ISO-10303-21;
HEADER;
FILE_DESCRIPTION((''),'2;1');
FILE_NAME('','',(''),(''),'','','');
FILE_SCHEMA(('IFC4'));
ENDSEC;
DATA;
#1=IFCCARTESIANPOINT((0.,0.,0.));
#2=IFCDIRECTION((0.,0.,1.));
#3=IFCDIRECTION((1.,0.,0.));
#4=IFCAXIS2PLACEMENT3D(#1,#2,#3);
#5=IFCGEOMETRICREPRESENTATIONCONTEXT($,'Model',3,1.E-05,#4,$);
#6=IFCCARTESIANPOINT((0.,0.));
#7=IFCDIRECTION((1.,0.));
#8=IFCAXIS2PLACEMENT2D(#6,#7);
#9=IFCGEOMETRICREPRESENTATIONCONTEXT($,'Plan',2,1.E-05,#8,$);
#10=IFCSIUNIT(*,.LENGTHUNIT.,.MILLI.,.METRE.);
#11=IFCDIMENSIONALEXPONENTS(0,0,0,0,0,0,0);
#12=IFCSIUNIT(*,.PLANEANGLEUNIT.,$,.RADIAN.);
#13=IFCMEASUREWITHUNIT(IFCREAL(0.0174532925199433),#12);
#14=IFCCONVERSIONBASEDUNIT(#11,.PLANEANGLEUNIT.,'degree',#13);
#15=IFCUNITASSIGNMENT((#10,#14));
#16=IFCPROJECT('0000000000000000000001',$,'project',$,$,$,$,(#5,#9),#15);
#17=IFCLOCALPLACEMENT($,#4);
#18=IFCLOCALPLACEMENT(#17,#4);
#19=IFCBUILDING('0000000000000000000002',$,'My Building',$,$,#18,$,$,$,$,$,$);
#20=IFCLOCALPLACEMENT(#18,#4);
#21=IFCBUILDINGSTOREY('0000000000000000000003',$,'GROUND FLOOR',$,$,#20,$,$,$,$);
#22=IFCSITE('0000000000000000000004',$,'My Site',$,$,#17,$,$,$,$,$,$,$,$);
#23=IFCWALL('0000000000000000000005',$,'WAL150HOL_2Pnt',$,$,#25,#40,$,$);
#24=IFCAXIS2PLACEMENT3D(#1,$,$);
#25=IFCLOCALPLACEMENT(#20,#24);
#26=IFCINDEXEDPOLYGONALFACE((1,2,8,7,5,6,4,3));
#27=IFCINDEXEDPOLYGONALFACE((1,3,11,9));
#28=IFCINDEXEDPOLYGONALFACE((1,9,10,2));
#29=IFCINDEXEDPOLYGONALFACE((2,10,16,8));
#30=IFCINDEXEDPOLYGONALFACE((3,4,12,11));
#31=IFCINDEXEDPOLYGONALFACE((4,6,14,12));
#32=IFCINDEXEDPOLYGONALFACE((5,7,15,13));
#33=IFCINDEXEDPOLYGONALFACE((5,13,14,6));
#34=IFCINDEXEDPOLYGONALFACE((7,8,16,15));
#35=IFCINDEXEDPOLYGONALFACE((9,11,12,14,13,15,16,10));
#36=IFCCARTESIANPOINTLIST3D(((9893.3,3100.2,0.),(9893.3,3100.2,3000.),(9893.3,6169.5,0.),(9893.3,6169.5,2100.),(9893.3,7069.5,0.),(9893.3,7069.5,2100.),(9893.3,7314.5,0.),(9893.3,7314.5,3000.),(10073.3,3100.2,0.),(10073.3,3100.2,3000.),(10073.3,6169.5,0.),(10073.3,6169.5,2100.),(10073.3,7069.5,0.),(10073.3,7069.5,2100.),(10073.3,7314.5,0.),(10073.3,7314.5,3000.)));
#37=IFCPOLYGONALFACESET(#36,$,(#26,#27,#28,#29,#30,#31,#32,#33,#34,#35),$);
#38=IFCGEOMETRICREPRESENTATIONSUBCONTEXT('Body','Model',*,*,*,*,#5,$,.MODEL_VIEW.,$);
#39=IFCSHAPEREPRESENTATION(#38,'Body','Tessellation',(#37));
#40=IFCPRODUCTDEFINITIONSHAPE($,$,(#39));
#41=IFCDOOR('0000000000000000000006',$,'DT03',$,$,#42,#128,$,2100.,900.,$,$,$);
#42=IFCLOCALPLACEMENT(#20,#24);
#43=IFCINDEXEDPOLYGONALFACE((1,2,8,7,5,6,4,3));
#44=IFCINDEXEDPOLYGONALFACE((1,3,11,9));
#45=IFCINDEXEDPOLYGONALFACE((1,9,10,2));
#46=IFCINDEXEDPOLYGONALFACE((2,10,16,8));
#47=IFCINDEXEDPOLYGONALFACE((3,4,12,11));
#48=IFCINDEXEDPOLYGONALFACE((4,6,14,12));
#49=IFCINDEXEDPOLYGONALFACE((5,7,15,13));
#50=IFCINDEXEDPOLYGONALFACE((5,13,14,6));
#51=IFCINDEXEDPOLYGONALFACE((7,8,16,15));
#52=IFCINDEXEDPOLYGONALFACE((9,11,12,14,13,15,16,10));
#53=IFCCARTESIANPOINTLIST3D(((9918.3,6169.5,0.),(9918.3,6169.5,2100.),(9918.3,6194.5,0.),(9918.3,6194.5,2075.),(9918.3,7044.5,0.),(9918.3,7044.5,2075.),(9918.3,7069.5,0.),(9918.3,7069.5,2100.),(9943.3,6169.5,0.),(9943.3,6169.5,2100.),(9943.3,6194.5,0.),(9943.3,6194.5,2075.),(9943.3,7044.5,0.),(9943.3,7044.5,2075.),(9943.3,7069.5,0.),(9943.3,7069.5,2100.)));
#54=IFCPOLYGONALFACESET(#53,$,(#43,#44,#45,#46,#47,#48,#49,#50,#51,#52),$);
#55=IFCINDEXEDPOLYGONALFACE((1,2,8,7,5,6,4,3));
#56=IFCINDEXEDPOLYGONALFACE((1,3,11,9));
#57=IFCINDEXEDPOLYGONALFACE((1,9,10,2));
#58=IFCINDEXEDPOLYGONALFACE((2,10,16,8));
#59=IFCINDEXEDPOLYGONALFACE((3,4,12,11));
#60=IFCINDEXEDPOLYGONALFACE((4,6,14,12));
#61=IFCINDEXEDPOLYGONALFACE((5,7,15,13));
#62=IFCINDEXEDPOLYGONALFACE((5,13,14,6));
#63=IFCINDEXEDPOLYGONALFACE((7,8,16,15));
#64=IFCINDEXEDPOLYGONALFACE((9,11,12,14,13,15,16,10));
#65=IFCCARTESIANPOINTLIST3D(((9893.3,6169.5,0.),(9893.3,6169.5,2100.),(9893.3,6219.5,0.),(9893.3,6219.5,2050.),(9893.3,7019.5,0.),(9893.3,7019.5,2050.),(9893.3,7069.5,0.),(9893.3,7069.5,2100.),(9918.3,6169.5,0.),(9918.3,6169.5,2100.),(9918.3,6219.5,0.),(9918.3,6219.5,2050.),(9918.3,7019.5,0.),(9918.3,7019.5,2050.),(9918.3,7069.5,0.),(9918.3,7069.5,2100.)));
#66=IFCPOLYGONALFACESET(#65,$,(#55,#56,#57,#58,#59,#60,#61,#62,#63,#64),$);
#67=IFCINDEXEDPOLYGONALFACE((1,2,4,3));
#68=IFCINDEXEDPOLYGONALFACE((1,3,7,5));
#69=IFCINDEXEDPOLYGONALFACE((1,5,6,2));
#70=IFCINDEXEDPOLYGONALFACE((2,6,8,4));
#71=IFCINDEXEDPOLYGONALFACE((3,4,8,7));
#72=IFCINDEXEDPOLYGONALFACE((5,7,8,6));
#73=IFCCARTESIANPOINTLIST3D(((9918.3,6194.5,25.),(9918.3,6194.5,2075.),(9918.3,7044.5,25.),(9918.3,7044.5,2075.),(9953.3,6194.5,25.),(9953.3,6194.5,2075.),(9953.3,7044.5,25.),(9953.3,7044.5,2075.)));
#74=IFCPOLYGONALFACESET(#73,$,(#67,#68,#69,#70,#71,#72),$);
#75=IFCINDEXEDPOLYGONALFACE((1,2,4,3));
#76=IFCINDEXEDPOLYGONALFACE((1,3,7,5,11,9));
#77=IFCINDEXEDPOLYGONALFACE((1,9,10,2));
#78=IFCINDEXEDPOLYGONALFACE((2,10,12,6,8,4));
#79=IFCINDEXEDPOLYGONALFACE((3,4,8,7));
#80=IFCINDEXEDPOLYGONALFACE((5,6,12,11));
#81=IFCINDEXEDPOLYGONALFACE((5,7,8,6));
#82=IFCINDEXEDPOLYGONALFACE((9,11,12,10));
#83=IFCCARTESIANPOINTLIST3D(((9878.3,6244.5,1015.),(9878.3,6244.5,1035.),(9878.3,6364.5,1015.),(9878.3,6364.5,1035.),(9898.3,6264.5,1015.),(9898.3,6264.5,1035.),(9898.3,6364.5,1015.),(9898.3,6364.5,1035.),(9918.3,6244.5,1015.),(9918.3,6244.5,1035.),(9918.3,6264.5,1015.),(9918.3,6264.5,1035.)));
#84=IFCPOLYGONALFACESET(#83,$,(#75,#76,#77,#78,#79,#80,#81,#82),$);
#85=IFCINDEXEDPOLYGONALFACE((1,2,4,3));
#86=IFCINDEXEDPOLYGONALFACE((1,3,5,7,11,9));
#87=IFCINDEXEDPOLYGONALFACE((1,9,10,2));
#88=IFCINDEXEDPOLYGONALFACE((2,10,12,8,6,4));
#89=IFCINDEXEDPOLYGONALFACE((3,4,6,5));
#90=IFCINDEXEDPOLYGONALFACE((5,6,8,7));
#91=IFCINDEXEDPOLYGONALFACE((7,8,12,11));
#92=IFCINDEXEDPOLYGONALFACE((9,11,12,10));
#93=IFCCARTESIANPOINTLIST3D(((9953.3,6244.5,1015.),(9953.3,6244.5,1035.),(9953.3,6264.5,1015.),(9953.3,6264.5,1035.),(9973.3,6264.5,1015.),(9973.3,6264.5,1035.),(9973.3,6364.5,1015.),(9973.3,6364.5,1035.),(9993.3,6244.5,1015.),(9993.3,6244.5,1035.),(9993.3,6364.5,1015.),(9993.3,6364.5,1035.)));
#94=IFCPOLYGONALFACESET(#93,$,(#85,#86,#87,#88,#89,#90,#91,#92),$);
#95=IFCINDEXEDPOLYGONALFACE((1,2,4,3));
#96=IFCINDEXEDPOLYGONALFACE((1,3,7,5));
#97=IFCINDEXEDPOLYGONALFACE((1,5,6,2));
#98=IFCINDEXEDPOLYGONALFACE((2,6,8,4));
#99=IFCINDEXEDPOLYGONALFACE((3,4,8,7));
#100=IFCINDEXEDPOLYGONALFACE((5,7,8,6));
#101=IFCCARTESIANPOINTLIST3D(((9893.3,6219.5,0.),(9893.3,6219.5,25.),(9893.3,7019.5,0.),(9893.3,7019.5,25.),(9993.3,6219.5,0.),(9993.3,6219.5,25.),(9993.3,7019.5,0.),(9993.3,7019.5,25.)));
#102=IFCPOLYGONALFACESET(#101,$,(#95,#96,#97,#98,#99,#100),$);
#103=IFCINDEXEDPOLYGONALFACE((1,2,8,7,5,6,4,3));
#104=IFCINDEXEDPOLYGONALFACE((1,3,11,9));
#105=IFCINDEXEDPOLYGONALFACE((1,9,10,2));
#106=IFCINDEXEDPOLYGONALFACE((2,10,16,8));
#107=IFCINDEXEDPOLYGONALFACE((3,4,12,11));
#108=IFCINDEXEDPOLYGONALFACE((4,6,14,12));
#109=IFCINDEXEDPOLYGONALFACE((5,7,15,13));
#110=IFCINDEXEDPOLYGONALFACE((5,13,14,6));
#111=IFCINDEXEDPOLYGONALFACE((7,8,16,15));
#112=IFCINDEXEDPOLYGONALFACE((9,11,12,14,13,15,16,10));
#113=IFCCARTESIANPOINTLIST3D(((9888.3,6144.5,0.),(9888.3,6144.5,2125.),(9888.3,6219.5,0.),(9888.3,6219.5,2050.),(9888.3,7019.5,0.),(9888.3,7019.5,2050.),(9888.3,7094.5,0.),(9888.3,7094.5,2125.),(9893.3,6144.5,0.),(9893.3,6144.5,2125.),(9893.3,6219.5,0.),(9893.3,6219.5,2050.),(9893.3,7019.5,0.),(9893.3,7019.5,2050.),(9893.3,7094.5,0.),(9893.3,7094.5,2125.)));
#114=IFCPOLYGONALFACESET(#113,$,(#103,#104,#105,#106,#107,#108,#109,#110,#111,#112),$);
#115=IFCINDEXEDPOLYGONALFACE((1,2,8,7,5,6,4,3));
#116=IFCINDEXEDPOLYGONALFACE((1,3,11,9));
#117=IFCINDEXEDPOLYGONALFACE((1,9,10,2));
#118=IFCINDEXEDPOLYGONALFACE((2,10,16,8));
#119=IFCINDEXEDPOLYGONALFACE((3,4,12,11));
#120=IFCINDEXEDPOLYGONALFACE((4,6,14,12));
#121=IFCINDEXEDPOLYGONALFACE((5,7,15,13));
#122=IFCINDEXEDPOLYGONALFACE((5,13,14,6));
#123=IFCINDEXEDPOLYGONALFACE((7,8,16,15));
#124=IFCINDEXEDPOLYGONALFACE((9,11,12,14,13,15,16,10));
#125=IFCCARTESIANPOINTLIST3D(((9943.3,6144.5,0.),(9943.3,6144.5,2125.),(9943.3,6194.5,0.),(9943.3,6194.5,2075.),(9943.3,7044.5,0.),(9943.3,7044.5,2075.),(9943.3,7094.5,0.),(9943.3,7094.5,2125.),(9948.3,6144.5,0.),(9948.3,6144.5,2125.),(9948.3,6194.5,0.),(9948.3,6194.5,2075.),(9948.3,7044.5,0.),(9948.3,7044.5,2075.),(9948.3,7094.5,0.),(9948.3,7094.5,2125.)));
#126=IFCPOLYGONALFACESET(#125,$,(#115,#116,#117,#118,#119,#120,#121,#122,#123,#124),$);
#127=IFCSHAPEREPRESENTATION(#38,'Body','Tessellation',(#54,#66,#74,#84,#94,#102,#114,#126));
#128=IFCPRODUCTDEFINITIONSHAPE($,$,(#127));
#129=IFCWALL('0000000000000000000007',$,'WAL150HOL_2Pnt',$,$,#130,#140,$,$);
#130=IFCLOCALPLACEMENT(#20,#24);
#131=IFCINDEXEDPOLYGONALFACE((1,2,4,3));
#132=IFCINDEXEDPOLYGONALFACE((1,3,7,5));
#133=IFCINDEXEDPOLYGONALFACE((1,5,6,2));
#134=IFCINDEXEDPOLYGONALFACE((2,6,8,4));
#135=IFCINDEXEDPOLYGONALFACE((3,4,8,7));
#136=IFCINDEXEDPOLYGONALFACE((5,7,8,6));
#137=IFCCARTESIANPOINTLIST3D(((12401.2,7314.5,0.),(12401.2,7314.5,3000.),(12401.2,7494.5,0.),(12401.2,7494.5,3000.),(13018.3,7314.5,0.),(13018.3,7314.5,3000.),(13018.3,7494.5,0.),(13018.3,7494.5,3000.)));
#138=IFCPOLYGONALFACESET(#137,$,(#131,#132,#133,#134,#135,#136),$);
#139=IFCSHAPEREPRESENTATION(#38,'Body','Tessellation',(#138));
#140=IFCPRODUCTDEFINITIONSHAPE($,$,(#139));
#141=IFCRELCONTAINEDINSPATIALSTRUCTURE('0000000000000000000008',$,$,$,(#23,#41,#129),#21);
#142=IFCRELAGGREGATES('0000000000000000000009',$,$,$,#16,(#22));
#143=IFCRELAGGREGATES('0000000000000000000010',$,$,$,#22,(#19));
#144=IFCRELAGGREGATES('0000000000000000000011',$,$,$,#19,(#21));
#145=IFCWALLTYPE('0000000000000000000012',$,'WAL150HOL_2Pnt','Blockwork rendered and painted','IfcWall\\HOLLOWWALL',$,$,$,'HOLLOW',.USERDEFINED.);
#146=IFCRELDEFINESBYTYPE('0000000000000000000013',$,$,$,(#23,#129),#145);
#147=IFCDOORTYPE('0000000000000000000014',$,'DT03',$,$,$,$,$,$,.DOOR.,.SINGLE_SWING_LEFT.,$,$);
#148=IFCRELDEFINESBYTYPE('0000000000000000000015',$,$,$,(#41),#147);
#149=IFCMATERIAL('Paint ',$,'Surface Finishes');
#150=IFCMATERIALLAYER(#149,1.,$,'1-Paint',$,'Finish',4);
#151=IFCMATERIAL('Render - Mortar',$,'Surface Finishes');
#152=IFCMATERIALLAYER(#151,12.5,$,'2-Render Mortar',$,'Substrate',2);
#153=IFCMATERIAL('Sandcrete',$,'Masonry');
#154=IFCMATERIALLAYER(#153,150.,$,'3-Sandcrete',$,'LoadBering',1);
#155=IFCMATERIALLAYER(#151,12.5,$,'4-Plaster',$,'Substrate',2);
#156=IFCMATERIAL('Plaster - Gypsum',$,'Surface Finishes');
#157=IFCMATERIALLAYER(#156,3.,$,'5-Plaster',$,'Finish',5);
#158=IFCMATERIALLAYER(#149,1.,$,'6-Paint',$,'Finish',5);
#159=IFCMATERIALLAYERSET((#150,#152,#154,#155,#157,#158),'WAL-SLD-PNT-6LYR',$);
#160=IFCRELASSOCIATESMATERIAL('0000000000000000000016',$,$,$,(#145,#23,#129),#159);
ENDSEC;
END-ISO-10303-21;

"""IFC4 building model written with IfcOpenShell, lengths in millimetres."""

from ifc_helpers import new_model, entity, si_unit, converted_unit, frame, origin_with_axes, origin_2d_with_axis, place, context, subcontext, project, spatial, line, indexed_curve, outline, extrude, shape, source, transform, mapped, material, layer, layer_set, layer_usage, type_object, type_shapes, element, fill, save


model = new_model("IFC4")

# Units and contexts
model_context = context("Model", 3, precision=1e-05, world=origin_with_axes())
plan_context = context("Plan", 2, precision=1e-05, world=origin_2d_with_axis())
body_context_1 = subcontext(model_context, "Body", "Model", "MODEL_VIEW")
body_context_2 = subcontext(plan_context, "Body", "Plan", "PLAN_VIEW")
ifc_project = project(units=[si_unit("LENGTHUNIT", "METRE", prefix="MILLI"), converted_unit("PLANEANGLEUNIT", "degree", entity("IfcReal", 0.0174532925199433), si_unit("PLANEANGLEUNIT", "RADIAN"), dimensions=[0, 0, 0, 0, 0, 0, 0])], contexts=[model_context, plan_context])

# Site, building, storey
site_placement = place(None, origin_with_axes())
site = spatial("IfcSite", under=ifc_project, at=site_placement, Name="My Site")
building_placement = place(site_placement, origin_with_axes())
building = spatial("IfcBuilding", under=site, at=building_placement, Name="My Building")
storey_placement = place(building_placement, origin_with_axes())
storey = spatial("IfcBuildingStorey", under=building, at=storey_placement, Name="GROUND FLOOR")

# Shared definitions
ifc_material_1 = material(Name="Paint ", Category="Surface Finishes")
ifc_layer_1 = layer(ifc_material_1, 1.0, Name="1-Paint", Category="Finish", Priority=4)
ifc_material_2 = material(Name="Render - Mortar", Category="Surface Finishes")
ifc_layer_2 = layer(ifc_material_2, 12.5, Name="2-Render Mortar", Category="Substrate", Priority=2)
ifc_material_3 = material(Name="Sandcrete", Category="Masonry")
ifc_layer_3 = layer(ifc_material_3, 150.0, Name="3-Sandcrete", Category="LoadBering", Priority=1)
ifc_layer_4 = layer(ifc_material_2, 12.5, Name="4-Plaster", Category="Substrate", Priority=2)
ifc_material_4 = material(Name="Plaster - Gypsum", Category="Surface Finishes")
ifc_layer_5 = layer(ifc_material_4, 3.0, Name="5-Plaster", Category="Finish", Priority=5)
ifc_layer_6 = layer(ifc_material_1, 1.0, Name="6-Paint", Category="Finish", Priority=5)
ifc_layer_set_1 = layer_set([ifc_layer_1, ifc_layer_2, ifc_layer_3, ifc_layer_4, ifc_layer_5, ifc_layer_6], Name="WAL-SLD-PNT-6LYR")
wall_type_1 = type_object("IfcWallType", Name="WAL150HOL_2Pnt", Description="Blockwork rendered and painted", ApplicableOccurrence="IfcWall\\HOLLOWWALL", ElementType="HOLLOW", PredefinedType="USERDEFINED", material=ifc_layer_set_1)
shared_shape_1 = source(origin_with_axes(), body_context_1, "Body", "SweptSolid", [
    extrude(outline(indexed_curve([(0.0, 0.0), (900.0, 0.0), (900.0, 2100.0), (0.0, 2100.0)], segments=[line(1, 2, 3, 4, 1)])), frame((0.0, -100.0, 0.0), z_axis=(0.0, -1.0, 0.0), x_axis=(1.0, 0.0, 0.0)), (0.0, 0.0, -1.0), 380.0),
])
door_type_1 = type_object("IfcDoorType", Name="DT03", OperationType="SINGLE_SWING_LEFT", PredefinedType="DOOR")
shared_shape_2 = source(origin_with_axes(), body_context_1, "Body", "SweptSolid", [
    extrude(outline(indexed_curve([(0.0, 0.0), (0.0, 2100.0), (900.0, 2100.0), (900.0, 0.0), (875.0, 0.0), (875.0, 2075.0), (25.0, 2075.0), (25.0, 0.0)], segments=[line(1, 2, 3, 4, 5, 6, 7, 8, 1)])), frame((0.0, 25.0, 0.0), z_axis=(0.0, -1.0, 0.0), x_axis=(1.0, 0.0, 0.0)), (0.0, 0.0, -1.0), 25.0),
    extrude(outline(indexed_curve([(0.0, 0.0), (0.0, 2100.0), (900.0, 2100.0), (900.0, 0.0), (850.0, 0.0), (850.0, 2050.0), (50.0, 2050.0), (50.0, 0.0)], segments=[line(1, 2, 3, 4, 5, 6, 7, 8, 1)])), frame((0.0, 0.0, 0.0), z_axis=(0.0, -1.0, 0.0), x_axis=(1.0, 0.0, 0.0)), (0.0, 0.0, -1.0), 25.0),
    extrude(outline(indexed_curve([(0.0, 0.0), (850.0, 0.0), (850.0, 35.0), (0.0, 35.0)], segments=[line(1, 2, 3, 4, 1)])), frame((25.0, 25.0, 25.0), z_axis=(0.0, 0.0, 1.0), x_axis=(1.0, 0.0, 0.0)), (0.0, 0.0, 1.0), 2050.0),
    extrude(outline(indexed_curve([(0.0, 0.0), (0.0, -40.0), (-120.0, -40.0), (-120.0, -20.0), (-20.0, -20.0), (-20.0, 0.0)], segments=[line(1, 2, 3, 4, 5, 6, 1)])), frame((825.0, 25.0, 1015.0), z_axis=(0.0, 0.0, 1.0), x_axis=(1.0, 0.0, 0.0)), (0.0, 0.0, 1.0), 20.0),
    extrude(outline(indexed_curve([(0.0, 0.0), (0.0, 40.0), (-120.0, 40.0), (-120.0, 20.0), (-20.0, 20.0), (-20.0, 0.0)], segments=[line(1, 2, 3, 4, 5, 6, 1)])), frame((825.0, 60.0, 1015.0), z_axis=(0.0, 0.0, 1.0), x_axis=(1.0, 0.0, 0.0)), (0.0, 0.0, 1.0), 20.0),
    extrude(outline(indexed_curve([(0.0, 0.0), (800.0, 0.0), (800.0, 100.0), (0.0, 100.0)], segments=[line(1, 2, 3, 4, 1)])), frame((50.0, 0.0, 0.0), z_axis=(0.0, 0.0, 1.0), x_axis=(1.0, 0.0, 0.0)), (0.0, 0.0, 1.0), 25.0),
    extrude(outline(indexed_curve([(0.0, 0.0), (0.0, 2125.0), (950.0, 2125.0), (950.0, 0.0), (875.0, 0.0), (875.0, 2050.0), (75.0, 2050.0), (75.0, 0.0)], segments=[line(1, 2, 3, 4, 5, 6, 7, 8, 1)])), frame((-25.0, -5.0, 0.0), z_axis=(0.0, -1.0, 0.0), x_axis=(1.0, 0.0, 0.0)), (0.0, 0.0, -1.0), 5.0),
    extrude(outline(indexed_curve([(0.0, 0.0), (0.0, 2125.0), (950.0, 2125.0), (950.0, 0.0), (900.0, 0.0), (900.0, 2075.0), (50.0, 2075.0), (50.0, 0.0)], segments=[line(1, 2, 3, 4, 5, 6, 7, 8, 1)])), frame((-25.0, 50.0, 0.0), z_axis=(0.0, -1.0, 0.0), x_axis=(1.0, 0.0, 0.0)), (0.0, 0.0, -1.0), 5.0),
])
shared_shape_3 = source(origin_with_axes(), body_context_2, "Body", "Curve2D", [
    entity("IfcIndexedPolyCurve", entity("IfcCartesianPointList2D", [[0.0, 0.0], [0.0, 50.0], [25.0, 50.0], [25.0, 25.0], [50.0, 25.0], [50.0, 0.0]]), [entity("IfcLineIndex", [1, 2, 3, 4, 5, 6, 1])]),
    entity("IfcIndexedPolyCurve", entity("IfcCartesianPointList2D", [[900.0, 0.0], [900.0, 50.0], [875.0, 50.0], [875.0, 25.0], [850.0, 25.0], [850.0, 0.0]]), [entity("IfcLineIndex", [1, 2, 3, 4, 5, 6, 1])]),
    entity("IfcTrimmedCurve", entity("IfcEllipse", entity("IfcAxis2Placement2D", entity("IfcCartesianPoint", [60.0, 50.0]), entity("IfcDirection", [1.0, 0.0])), 815.0, 850.0), [entity("IfcCartesianPoint", [875.0, 50.0])], [entity("IfcCartesianPoint", [60.0, 900.0])], True, "CARTESIAN"),
    entity("IfcIndexedPolyCurve", entity("IfcCartesianPointList2D", [[25.0, 50.0], [60.0, 50.0], [60.0, 900.0], [25.0, 900.0]]), [entity("IfcLineIndex", [1, 2, 3, 4, 1])]),
])
type_shapes(door_type_1, [shared_shape_2, shared_shape_3])

# Wall, opening, door
ifc_layer_usage_1 = layer_usage(ifc_layer_set_1, "AXIS2", "POSITIVE", 0.0)
wall_1_placement = place(storey_placement, frame((9893.3, 7314.5, 0.0), z_axis=(0.0, 0.0, 1.0), x_axis=(-0.000001, -1.0, 0.0)))
wall_1 = element("IfcWall", 1, at=wall_1_placement, inside=storey, type_object=wall_type_1, material=ifc_layer_usage_1, Name="WAL150HOL_2Pnt", context=body_context_1, shape_type="SweptSolid", body=[
    extrude(outline(indexed_curve([(0.0, 0.0), (0.0, 180.0), (4214.3, 180.0), (4214.3, 0.0), (0.0, 0.0)], self_intersect=False)), origin_with_axes(), (0.0, 0.0, 1.0), 3000.0),
])
opening_1_placement = place(wall_1_placement, frame((245.0, 0.0, 0.0), z_axis=(0.0, 0.0, 1.0), x_axis=(1.0, 0.0, 0.0)))
opening_1 = element("IfcOpeningElement", 2, at=opening_1_placement, cuts=wall_1, PredefinedType="OPENING", context=body_context_1, shape_type="MappedRepresentation", body=[
    mapped(shared_shape_1, transform((0.0, 0.0, 0.0), x_axis=(1.0, 0.0, 0.0), y_axis=(0.0, 1.0, 0.0), z_axis=(0.0, 0.0, 1.0), scale=1.0)),
])
door_1_placement = place(opening_1_placement, frame((0.0, 0.0, 0.0), z_axis=(0.0, 0.0, 1.0), x_axis=(1.0, 0.0, 0.0)))
door_1 = element("IfcDoor", 3, at=door_1_placement, inside=storey, type_object=door_type_1, Name="DT03", OverallHeight=2100.0, OverallWidth=900.0, shapes=[
    shape(body_context_1, "Body", "MappedRepresentation", [mapped(shared_shape_2, transform((0.0, 0.0, 0.0), x_axis=(1.0, 0.0, 0.0), y_axis=(0.0, 1.0, 0.0), z_axis=(0.0, 0.0, 1.0), scale=1.0))]),
    shape(body_context_2, "Body", "MappedRepresentation", [mapped(shared_shape_3, transform((0.0, 0.0, 0.0), x_axis=(1.0, 0.0, 0.0), y_axis=(0.0, 1.0, 0.0), z_axis=(0.0, 0.0, 1.0), scale=1.0))]),
])
fill(opening_1, door_1)

# Wall
ifc_layer_usage_2 = layer_usage(ifc_layer_set_1, "AXIS2", "POSITIVE", 0.0)
wall_2_placement = place(storey_placement, frame((13018.3, 7494.5, 0.0), z_axis=(0.0, 0.0, 1.0), x_axis=(-1.0, 0.000001, 0.0)))
element("IfcWall", 4, at=wall_2_placement, inside=storey, type_object=wall_type_1, material=ifc_layer_usage_2, Name="WAL150HOL_2Pnt", context=body_context_1, shape_type="SweptSolid", body=[
    extrude(outline(indexed_curve([(0.0, 0.0), (0.0, 180.0), (617.1, 180.0), (617.1, 0.0), (0.0, 0.0)], self_intersect=False)), origin_with_axes(), (0.0, 0.0, 1.0), 3000.0),
])

save(model, "model.ifc")
